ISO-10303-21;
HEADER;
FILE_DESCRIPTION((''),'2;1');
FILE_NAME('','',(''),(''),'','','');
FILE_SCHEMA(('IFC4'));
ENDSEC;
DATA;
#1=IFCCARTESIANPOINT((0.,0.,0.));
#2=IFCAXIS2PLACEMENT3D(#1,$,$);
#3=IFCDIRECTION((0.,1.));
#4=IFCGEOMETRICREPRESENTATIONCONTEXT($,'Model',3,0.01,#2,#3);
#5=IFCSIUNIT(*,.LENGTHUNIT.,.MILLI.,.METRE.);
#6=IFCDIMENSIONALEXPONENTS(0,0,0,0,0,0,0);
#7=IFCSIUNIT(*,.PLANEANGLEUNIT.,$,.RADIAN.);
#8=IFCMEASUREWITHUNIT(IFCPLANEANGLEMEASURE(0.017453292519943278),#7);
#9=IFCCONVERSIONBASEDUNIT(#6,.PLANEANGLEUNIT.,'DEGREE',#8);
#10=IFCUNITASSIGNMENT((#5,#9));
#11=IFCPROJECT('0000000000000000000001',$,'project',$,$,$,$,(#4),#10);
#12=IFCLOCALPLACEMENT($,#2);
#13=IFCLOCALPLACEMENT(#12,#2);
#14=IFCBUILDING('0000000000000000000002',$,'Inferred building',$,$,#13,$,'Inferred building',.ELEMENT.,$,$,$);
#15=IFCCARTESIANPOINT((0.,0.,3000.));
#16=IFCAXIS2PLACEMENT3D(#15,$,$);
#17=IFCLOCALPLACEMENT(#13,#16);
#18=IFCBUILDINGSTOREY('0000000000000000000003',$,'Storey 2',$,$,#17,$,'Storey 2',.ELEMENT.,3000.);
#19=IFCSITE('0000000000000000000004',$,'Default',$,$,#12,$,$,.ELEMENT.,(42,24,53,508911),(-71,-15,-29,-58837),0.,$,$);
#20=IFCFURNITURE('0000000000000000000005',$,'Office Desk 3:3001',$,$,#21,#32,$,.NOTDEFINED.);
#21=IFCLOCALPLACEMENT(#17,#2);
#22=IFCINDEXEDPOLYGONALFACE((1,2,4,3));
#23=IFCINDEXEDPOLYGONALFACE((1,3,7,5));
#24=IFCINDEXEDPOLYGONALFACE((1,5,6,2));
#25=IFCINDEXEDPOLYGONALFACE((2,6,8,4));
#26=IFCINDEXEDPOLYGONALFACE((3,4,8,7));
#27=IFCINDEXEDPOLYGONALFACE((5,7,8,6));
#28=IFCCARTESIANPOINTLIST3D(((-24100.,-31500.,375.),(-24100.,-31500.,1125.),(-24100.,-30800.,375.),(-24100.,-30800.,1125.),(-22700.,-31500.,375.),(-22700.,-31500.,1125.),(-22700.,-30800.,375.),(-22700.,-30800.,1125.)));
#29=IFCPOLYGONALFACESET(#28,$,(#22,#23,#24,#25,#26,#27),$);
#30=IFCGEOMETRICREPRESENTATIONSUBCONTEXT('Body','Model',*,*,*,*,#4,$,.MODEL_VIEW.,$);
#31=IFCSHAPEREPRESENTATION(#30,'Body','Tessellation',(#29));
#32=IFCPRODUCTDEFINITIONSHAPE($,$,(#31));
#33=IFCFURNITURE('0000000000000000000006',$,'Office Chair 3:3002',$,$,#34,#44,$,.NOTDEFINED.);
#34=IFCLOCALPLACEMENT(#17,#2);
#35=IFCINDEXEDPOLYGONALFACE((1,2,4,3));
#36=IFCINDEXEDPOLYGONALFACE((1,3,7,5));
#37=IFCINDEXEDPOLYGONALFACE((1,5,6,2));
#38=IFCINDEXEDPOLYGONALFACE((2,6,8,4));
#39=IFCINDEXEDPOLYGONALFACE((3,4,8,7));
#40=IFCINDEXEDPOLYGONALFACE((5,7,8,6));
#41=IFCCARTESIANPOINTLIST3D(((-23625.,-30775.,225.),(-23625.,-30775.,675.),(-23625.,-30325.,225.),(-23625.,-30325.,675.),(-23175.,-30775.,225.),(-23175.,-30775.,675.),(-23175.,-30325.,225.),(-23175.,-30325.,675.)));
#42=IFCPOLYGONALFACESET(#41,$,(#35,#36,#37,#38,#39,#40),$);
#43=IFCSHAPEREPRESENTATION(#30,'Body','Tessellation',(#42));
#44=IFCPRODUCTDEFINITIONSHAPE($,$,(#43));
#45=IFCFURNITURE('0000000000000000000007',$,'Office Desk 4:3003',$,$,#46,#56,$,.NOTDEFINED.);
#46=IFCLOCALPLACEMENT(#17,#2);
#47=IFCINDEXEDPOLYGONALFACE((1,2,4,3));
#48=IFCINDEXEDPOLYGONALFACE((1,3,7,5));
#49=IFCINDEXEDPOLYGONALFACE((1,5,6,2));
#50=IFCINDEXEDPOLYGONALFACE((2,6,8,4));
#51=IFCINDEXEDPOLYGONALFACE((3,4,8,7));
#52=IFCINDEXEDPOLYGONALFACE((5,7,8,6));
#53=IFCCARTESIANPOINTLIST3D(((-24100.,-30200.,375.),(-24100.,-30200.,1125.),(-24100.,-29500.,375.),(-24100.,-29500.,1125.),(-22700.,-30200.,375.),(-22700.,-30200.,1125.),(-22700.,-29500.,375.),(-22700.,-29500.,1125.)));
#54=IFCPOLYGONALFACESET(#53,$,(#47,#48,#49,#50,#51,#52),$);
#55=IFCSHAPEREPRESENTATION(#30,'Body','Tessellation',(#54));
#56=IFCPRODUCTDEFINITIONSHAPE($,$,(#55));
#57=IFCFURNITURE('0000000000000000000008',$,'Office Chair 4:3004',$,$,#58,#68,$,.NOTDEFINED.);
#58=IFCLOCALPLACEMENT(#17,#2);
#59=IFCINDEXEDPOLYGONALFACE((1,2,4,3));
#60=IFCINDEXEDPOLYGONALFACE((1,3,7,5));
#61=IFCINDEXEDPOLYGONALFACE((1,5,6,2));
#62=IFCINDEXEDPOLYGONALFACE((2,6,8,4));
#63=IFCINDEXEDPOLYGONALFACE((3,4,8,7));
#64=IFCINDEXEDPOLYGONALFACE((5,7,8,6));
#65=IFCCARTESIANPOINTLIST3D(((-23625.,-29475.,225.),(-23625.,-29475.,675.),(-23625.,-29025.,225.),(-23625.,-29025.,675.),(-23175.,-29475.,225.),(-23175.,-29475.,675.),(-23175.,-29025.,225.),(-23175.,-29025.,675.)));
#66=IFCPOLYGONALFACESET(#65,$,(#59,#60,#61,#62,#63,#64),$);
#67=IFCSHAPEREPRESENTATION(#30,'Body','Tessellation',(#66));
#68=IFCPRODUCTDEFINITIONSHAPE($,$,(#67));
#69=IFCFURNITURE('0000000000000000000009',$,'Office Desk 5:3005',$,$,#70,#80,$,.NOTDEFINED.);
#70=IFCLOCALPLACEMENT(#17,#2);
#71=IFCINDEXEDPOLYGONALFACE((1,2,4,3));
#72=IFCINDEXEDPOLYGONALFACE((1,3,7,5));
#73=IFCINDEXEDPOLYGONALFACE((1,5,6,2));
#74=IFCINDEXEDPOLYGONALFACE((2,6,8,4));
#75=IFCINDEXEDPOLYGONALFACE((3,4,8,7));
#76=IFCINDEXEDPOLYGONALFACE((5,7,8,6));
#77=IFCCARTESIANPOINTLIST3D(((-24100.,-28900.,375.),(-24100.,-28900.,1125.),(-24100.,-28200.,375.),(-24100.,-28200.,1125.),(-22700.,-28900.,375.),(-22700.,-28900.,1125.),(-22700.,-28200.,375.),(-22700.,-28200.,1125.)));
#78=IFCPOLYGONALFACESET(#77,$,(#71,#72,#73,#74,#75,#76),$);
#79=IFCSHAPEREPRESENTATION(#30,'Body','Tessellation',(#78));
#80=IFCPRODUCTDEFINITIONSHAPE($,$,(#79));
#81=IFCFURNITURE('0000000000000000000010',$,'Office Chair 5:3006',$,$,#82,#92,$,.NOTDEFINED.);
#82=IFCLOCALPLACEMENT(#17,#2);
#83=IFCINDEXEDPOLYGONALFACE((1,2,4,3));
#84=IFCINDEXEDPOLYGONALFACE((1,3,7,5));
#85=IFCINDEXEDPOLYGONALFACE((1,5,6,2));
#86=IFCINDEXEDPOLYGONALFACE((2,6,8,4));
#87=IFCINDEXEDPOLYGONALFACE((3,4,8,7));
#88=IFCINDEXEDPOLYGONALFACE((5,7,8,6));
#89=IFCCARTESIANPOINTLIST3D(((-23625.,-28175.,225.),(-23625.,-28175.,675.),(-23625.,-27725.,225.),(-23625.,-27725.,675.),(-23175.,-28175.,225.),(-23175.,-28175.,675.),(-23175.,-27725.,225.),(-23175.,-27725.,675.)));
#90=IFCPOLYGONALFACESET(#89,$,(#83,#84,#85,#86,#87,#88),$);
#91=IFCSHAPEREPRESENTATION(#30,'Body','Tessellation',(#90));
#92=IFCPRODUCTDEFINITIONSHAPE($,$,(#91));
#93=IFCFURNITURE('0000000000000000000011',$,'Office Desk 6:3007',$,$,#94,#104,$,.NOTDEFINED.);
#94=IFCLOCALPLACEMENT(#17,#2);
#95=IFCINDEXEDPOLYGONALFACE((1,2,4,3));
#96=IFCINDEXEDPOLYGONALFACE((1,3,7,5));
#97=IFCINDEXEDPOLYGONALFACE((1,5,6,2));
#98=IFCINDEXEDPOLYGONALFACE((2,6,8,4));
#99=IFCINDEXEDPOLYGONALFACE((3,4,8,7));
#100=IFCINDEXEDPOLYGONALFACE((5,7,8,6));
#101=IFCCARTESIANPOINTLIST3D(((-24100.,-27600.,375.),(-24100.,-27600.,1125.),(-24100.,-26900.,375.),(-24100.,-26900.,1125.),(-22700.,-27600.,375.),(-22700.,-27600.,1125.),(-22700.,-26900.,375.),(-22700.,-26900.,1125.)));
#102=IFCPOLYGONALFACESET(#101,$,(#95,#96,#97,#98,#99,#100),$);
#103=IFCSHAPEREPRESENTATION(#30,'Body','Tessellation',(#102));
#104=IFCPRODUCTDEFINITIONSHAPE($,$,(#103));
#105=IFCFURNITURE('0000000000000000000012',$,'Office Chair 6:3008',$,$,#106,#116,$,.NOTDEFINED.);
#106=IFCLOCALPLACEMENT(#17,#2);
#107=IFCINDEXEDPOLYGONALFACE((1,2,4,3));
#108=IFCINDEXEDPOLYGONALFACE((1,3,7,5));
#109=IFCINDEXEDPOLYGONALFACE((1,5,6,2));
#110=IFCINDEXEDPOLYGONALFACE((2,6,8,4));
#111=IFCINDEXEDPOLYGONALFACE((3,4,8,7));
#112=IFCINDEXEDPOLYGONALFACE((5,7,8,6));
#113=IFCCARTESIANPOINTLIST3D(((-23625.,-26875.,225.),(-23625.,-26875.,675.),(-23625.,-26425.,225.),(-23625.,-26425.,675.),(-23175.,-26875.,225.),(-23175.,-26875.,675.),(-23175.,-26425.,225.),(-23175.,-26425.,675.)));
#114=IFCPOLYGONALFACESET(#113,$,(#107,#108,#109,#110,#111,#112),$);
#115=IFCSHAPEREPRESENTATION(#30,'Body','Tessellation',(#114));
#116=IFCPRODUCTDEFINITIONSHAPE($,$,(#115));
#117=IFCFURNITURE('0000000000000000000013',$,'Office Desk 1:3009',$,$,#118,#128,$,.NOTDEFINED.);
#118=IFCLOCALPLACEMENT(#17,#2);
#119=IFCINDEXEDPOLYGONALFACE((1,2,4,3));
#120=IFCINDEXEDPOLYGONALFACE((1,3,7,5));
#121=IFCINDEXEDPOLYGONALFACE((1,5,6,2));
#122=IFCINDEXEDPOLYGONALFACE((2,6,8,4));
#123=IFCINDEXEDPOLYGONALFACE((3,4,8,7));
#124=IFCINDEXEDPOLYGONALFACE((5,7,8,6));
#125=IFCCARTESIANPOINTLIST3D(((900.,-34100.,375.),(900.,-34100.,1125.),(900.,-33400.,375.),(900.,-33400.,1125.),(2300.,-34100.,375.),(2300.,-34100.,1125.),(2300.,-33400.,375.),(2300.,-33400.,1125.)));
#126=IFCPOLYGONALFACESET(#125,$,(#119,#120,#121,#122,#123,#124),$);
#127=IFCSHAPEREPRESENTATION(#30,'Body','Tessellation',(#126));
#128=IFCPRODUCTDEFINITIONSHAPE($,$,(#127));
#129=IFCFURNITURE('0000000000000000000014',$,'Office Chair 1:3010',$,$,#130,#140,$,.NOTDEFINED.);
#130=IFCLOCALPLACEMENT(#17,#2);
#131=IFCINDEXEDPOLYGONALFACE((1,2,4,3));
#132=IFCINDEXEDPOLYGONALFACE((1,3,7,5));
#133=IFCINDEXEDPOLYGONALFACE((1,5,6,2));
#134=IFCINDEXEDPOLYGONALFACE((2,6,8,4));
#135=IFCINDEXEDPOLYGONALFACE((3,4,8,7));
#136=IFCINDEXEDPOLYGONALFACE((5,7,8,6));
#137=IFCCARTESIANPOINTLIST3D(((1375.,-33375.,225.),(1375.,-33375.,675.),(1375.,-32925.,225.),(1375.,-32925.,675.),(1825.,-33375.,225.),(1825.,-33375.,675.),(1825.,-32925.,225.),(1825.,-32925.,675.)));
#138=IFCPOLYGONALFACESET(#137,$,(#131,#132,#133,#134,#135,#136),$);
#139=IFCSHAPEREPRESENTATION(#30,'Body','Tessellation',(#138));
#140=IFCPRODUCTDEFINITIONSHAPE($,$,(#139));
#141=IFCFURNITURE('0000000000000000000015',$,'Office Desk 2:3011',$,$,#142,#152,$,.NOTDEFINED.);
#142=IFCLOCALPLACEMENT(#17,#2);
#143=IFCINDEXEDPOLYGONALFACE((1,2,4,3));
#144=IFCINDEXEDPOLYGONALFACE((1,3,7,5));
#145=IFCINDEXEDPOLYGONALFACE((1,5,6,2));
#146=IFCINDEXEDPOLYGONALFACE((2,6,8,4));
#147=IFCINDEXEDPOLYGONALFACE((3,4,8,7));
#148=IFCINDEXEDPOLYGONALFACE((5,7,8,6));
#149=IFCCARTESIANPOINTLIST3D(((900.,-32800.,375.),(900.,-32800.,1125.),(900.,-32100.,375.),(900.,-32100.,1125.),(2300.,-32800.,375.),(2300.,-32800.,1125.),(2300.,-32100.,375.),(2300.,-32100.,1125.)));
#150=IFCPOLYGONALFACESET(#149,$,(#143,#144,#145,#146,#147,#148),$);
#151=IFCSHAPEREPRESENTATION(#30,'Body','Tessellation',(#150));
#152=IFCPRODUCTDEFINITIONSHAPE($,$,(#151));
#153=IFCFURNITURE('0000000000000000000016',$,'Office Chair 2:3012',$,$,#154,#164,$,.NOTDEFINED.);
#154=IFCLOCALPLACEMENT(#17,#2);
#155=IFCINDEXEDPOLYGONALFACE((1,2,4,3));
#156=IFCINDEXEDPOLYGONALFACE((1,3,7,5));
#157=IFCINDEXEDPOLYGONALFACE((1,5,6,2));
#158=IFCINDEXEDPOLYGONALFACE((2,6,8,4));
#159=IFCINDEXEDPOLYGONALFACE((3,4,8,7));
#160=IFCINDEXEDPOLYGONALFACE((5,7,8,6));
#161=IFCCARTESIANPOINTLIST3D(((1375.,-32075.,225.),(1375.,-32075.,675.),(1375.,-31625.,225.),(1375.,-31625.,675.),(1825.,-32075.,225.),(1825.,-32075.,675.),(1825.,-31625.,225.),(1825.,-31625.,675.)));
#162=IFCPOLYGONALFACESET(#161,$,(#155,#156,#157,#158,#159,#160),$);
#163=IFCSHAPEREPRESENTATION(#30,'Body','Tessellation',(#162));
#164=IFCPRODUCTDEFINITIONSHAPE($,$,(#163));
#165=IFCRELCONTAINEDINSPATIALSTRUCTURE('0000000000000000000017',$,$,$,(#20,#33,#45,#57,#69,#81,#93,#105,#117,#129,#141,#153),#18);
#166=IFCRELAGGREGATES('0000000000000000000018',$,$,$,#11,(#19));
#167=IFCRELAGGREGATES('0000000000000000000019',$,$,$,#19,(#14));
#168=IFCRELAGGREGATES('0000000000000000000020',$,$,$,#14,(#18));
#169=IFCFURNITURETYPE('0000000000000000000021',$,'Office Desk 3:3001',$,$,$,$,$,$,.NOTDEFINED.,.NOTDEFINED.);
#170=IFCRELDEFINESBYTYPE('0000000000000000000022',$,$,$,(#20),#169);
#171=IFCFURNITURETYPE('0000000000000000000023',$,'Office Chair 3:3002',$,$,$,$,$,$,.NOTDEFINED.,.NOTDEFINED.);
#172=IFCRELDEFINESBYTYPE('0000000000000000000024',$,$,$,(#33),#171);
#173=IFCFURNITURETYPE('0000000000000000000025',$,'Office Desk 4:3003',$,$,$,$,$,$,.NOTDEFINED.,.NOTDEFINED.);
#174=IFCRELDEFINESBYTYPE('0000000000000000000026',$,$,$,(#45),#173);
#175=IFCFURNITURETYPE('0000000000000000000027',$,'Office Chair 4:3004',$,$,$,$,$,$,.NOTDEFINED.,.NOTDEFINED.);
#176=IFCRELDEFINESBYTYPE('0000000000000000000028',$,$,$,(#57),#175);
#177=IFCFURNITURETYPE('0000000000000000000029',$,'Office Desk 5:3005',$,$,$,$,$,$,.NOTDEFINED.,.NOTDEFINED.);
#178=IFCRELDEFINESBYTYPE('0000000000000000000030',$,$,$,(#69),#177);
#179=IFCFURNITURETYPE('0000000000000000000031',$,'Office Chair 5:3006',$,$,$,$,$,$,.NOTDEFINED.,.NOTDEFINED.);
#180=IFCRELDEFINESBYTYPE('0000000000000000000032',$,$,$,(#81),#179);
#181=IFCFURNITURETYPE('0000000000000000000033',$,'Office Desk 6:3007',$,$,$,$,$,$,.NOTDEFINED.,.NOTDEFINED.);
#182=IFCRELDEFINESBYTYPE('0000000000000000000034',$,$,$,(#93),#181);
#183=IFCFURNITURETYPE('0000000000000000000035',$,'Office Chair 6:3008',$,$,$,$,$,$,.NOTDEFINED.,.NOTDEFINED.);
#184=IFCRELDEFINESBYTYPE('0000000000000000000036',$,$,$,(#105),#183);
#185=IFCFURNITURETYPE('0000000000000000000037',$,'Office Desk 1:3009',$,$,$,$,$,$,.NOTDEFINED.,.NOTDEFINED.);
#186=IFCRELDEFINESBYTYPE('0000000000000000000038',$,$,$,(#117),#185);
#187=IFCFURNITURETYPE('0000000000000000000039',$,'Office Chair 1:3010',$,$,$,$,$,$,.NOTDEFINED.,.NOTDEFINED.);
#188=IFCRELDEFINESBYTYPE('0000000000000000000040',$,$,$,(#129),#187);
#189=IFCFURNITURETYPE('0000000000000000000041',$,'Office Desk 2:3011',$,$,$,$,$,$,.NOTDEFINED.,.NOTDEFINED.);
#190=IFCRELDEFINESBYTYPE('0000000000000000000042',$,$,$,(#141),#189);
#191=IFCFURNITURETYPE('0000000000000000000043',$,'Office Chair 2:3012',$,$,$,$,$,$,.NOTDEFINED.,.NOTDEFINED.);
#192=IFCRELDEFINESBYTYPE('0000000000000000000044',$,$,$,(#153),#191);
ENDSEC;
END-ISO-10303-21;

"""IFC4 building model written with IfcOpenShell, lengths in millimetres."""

from ifc_helpers import new_model, entity, si_unit, converted_unit, direction, frame, origin, origin_2d_with_axis, place, context, subcontext, project, spatial, rectangle, extrude, type_object, element, save


model = new_model("IFC4")

# Units and contexts
model_context = context("Model", 3, precision=0.01, world=origin(), true_north=direction((0.0, 1.0)))
body_context = subcontext(model_context, "Body", "Model", "MODEL_VIEW")
ifc_project = project(units=[si_unit("LENGTHUNIT", "METRE", prefix="MILLI"), converted_unit("PLANEANGLEUNIT", "DEGREE", entity("IfcPlaneAngleMeasure", 0.017453292519943278), si_unit("PLANEANGLEUNIT", "RADIAN"), dimensions=[0, 0, 0, 0, 0, 0, 0])], contexts=[model_context])

# Site, building, storey
site_placement = place(None, origin())
site = spatial("IfcSite", under=ifc_project, at=site_placement, Name="Default", CompositionType="ELEMENT", RefLatitude=(42, 24, 53, 508911), RefLongitude=(-71, -15, -29, -58837), RefElevation=0.0)
building_placement = place(site_placement, origin())
building = spatial("IfcBuilding", under=site, at=building_placement, Name="Inferred building", LongName="Inferred building", CompositionType="ELEMENT")
storey_placement = place(building_placement, frame((0.0, 0.0, 3000.0)))
storey = spatial("IfcBuildingStorey", under=building, at=storey_placement, Name="Storey 2", LongName="Storey 2", CompositionType="ELEMENT", Elevation=3000.0)

# Furniture
furniture_type_1 = type_object("IfcFurnitureType", Name="Office Desk 3:3001", PredefinedType="NOTDEFINED")
furniture_1_placement = place(storey_placement, origin())
element("IfcFurniture", 1, at=furniture_1_placement, inside=storey, type_object=furniture_type_1, Name="Office Desk 3:3001", PredefinedType="NOTDEFINED", context=body_context, shape_type="SweptSolid", body=[
    extrude(rectangle(XDim=1400.0, YDim=700.0, at=origin_2d_with_axis()), frame((-23400.0, -31150.0, 375.0)), (0.0, 0.0, 1.0), 750.0),
])
furniture_type_2 = type_object("IfcFurnitureType", Name="Office Chair 3:3002", PredefinedType="NOTDEFINED")
furniture_2_placement = place(storey_placement, origin())
element("IfcFurniture", 2, at=furniture_2_placement, inside=storey, type_object=furniture_type_2, Name="Office Chair 3:3002", PredefinedType="NOTDEFINED", context=body_context, shape_type="SweptSolid", body=[
    extrude(rectangle(XDim=450.0, YDim=450.0, at=origin_2d_with_axis()), frame((-23400.0, -30550.0, 225.0)), (0.0, 0.0, 1.0), 450.0),
])
furniture_type_3 = type_object("IfcFurnitureType", Name="Office Desk 4:3003", PredefinedType="NOTDEFINED")
furniture_3_placement = place(storey_placement, origin())
element("IfcFurniture", 3, at=furniture_3_placement, inside=storey, type_object=furniture_type_3, Name="Office Desk 4:3003", PredefinedType="NOTDEFINED", context=body_context, shape_type="SweptSolid", body=[
    extrude(rectangle(XDim=1400.0, YDim=700.0, at=origin_2d_with_axis()), frame((-23400.0, -29850.0, 375.0)), (0.0, 0.0, 1.0), 750.0),
])
furniture_type_4 = type_object("IfcFurnitureType", Name="Office Chair 4:3004", PredefinedType="NOTDEFINED")
furniture_4_placement = place(storey_placement, origin())
element("IfcFurniture", 4, at=furniture_4_placement, inside=storey, type_object=furniture_type_4, Name="Office Chair 4:3004", PredefinedType="NOTDEFINED", context=body_context, shape_type="SweptSolid", body=[
    extrude(rectangle(XDim=450.0, YDim=450.0, at=origin_2d_with_axis()), frame((-23400.0, -29250.0, 225.0)), (0.0, 0.0, 1.0), 450.0),
])
furniture_type_5 = type_object("IfcFurnitureType", Name="Office Desk 5:3005", PredefinedType="NOTDEFINED")
furniture_5_placement = place(storey_placement, origin())
element("IfcFurniture", 5, at=furniture_5_placement, inside=storey, type_object=furniture_type_5, Name="Office Desk 5:3005", PredefinedType="NOTDEFINED", context=body_context, shape_type="SweptSolid", body=[
    extrude(rectangle(XDim=1400.0, YDim=700.0, at=origin_2d_with_axis()), frame((-23400.0, -28550.0, 375.0)), (0.0, 0.0, 1.0), 750.0),
])
furniture_type_6 = type_object("IfcFurnitureType", Name="Office Chair 5:3006", PredefinedType="NOTDEFINED")
furniture_6_placement = place(storey_placement, origin())
element("IfcFurniture", 6, at=furniture_6_placement, inside=storey, type_object=furniture_type_6, Name="Office Chair 5:3006", PredefinedType="NOTDEFINED", context=body_context, shape_type="SweptSolid", body=[
    extrude(rectangle(XDim=450.0, YDim=450.0, at=origin_2d_with_axis()), frame((-23400.0, -27950.0, 225.0)), (0.0, 0.0, 1.0), 450.0),
])
furniture_type_7 = type_object("IfcFurnitureType", Name="Office Desk 6:3007", PredefinedType="NOTDEFINED")
furniture_7_placement = place(storey_placement, origin())
element("IfcFurniture", 7, at=furniture_7_placement, inside=storey, type_object=furniture_type_7, Name="Office Desk 6:3007", PredefinedType="NOTDEFINED", context=body_context, shape_type="SweptSolid", body=[
    extrude(rectangle(XDim=1400.0, YDim=700.0, at=origin_2d_with_axis()), frame((-23400.0, -27250.0, 375.0)), (0.0, 0.0, 1.0), 750.0),
])
furniture_type_8 = type_object("IfcFurnitureType", Name="Office Chair 6:3008", PredefinedType="NOTDEFINED")
furniture_8_placement = place(storey_placement, origin())
element("IfcFurniture", 8, at=furniture_8_placement, inside=storey, type_object=furniture_type_8, Name="Office Chair 6:3008", PredefinedType="NOTDEFINED", context=body_context, shape_type="SweptSolid", body=[
    extrude(rectangle(XDim=450.0, YDim=450.0, at=origin_2d_with_axis()), frame((-23400.0, -26650.0, 225.0)), (0.0, 0.0, 1.0), 450.0),
])
furniture_type_9 = type_object("IfcFurnitureType", Name="Office Desk 1:3009", PredefinedType="NOTDEFINED")
furniture_9_placement = place(storey_placement, origin())
element("IfcFurniture", 9, at=furniture_9_placement, inside=storey, type_object=furniture_type_9, Name="Office Desk 1:3009", PredefinedType="NOTDEFINED", context=body_context, shape_type="SweptSolid", body=[
    extrude(rectangle(XDim=1400.0, YDim=700.0, at=origin_2d_with_axis()), frame((1600.0, -33750.0, 375.0)), (0.0, 0.0, 1.0), 750.0),
])
furniture_type_10 = type_object("IfcFurnitureType", Name="Office Chair 1:3010", PredefinedType="NOTDEFINED")
furniture_10_placement = place(storey_placement, origin())
element("IfcFurniture", 10, at=furniture_10_placement, inside=storey, type_object=furniture_type_10, Name="Office Chair 1:3010", PredefinedType="NOTDEFINED", context=body_context, shape_type="SweptSolid", body=[
    extrude(rectangle(XDim=450.0, YDim=450.0, at=origin_2d_with_axis()), frame((1600.0, -33150.0, 225.0)), (0.0, 0.0, 1.0), 450.0),
])
furniture_type_11 = type_object("IfcFurnitureType", Name="Office Desk 2:3011", PredefinedType="NOTDEFINED")
furniture_11_placement = place(storey_placement, origin())
element("IfcFurniture", 11, at=furniture_11_placement, inside=storey, type_object=furniture_type_11, Name="Office Desk 2:3011", PredefinedType="NOTDEFINED", context=body_context, shape_type="SweptSolid", body=[
    extrude(rectangle(XDim=1400.0, YDim=700.0, at=origin_2d_with_axis()), frame((1600.0, -32450.0, 375.0)), (0.0, 0.0, 1.0), 750.0),
])
furniture_type_12 = type_object("IfcFurnitureType", Name="Office Chair 2:3012", PredefinedType="NOTDEFINED")
furniture_12_placement = place(storey_placement, origin())
element("IfcFurniture", 12, at=furniture_12_placement, inside=storey, type_object=furniture_type_12, Name="Office Chair 2:3012", PredefinedType="NOTDEFINED", context=body_context, shape_type="SweptSolid", body=[
    extrude(rectangle(XDim=450.0, YDim=450.0, at=origin_2d_with_axis()), frame((1600.0, -31850.0, 225.0)), (0.0, 0.0, 1.0), 450.0),
])

save(model, "model.ifc")
